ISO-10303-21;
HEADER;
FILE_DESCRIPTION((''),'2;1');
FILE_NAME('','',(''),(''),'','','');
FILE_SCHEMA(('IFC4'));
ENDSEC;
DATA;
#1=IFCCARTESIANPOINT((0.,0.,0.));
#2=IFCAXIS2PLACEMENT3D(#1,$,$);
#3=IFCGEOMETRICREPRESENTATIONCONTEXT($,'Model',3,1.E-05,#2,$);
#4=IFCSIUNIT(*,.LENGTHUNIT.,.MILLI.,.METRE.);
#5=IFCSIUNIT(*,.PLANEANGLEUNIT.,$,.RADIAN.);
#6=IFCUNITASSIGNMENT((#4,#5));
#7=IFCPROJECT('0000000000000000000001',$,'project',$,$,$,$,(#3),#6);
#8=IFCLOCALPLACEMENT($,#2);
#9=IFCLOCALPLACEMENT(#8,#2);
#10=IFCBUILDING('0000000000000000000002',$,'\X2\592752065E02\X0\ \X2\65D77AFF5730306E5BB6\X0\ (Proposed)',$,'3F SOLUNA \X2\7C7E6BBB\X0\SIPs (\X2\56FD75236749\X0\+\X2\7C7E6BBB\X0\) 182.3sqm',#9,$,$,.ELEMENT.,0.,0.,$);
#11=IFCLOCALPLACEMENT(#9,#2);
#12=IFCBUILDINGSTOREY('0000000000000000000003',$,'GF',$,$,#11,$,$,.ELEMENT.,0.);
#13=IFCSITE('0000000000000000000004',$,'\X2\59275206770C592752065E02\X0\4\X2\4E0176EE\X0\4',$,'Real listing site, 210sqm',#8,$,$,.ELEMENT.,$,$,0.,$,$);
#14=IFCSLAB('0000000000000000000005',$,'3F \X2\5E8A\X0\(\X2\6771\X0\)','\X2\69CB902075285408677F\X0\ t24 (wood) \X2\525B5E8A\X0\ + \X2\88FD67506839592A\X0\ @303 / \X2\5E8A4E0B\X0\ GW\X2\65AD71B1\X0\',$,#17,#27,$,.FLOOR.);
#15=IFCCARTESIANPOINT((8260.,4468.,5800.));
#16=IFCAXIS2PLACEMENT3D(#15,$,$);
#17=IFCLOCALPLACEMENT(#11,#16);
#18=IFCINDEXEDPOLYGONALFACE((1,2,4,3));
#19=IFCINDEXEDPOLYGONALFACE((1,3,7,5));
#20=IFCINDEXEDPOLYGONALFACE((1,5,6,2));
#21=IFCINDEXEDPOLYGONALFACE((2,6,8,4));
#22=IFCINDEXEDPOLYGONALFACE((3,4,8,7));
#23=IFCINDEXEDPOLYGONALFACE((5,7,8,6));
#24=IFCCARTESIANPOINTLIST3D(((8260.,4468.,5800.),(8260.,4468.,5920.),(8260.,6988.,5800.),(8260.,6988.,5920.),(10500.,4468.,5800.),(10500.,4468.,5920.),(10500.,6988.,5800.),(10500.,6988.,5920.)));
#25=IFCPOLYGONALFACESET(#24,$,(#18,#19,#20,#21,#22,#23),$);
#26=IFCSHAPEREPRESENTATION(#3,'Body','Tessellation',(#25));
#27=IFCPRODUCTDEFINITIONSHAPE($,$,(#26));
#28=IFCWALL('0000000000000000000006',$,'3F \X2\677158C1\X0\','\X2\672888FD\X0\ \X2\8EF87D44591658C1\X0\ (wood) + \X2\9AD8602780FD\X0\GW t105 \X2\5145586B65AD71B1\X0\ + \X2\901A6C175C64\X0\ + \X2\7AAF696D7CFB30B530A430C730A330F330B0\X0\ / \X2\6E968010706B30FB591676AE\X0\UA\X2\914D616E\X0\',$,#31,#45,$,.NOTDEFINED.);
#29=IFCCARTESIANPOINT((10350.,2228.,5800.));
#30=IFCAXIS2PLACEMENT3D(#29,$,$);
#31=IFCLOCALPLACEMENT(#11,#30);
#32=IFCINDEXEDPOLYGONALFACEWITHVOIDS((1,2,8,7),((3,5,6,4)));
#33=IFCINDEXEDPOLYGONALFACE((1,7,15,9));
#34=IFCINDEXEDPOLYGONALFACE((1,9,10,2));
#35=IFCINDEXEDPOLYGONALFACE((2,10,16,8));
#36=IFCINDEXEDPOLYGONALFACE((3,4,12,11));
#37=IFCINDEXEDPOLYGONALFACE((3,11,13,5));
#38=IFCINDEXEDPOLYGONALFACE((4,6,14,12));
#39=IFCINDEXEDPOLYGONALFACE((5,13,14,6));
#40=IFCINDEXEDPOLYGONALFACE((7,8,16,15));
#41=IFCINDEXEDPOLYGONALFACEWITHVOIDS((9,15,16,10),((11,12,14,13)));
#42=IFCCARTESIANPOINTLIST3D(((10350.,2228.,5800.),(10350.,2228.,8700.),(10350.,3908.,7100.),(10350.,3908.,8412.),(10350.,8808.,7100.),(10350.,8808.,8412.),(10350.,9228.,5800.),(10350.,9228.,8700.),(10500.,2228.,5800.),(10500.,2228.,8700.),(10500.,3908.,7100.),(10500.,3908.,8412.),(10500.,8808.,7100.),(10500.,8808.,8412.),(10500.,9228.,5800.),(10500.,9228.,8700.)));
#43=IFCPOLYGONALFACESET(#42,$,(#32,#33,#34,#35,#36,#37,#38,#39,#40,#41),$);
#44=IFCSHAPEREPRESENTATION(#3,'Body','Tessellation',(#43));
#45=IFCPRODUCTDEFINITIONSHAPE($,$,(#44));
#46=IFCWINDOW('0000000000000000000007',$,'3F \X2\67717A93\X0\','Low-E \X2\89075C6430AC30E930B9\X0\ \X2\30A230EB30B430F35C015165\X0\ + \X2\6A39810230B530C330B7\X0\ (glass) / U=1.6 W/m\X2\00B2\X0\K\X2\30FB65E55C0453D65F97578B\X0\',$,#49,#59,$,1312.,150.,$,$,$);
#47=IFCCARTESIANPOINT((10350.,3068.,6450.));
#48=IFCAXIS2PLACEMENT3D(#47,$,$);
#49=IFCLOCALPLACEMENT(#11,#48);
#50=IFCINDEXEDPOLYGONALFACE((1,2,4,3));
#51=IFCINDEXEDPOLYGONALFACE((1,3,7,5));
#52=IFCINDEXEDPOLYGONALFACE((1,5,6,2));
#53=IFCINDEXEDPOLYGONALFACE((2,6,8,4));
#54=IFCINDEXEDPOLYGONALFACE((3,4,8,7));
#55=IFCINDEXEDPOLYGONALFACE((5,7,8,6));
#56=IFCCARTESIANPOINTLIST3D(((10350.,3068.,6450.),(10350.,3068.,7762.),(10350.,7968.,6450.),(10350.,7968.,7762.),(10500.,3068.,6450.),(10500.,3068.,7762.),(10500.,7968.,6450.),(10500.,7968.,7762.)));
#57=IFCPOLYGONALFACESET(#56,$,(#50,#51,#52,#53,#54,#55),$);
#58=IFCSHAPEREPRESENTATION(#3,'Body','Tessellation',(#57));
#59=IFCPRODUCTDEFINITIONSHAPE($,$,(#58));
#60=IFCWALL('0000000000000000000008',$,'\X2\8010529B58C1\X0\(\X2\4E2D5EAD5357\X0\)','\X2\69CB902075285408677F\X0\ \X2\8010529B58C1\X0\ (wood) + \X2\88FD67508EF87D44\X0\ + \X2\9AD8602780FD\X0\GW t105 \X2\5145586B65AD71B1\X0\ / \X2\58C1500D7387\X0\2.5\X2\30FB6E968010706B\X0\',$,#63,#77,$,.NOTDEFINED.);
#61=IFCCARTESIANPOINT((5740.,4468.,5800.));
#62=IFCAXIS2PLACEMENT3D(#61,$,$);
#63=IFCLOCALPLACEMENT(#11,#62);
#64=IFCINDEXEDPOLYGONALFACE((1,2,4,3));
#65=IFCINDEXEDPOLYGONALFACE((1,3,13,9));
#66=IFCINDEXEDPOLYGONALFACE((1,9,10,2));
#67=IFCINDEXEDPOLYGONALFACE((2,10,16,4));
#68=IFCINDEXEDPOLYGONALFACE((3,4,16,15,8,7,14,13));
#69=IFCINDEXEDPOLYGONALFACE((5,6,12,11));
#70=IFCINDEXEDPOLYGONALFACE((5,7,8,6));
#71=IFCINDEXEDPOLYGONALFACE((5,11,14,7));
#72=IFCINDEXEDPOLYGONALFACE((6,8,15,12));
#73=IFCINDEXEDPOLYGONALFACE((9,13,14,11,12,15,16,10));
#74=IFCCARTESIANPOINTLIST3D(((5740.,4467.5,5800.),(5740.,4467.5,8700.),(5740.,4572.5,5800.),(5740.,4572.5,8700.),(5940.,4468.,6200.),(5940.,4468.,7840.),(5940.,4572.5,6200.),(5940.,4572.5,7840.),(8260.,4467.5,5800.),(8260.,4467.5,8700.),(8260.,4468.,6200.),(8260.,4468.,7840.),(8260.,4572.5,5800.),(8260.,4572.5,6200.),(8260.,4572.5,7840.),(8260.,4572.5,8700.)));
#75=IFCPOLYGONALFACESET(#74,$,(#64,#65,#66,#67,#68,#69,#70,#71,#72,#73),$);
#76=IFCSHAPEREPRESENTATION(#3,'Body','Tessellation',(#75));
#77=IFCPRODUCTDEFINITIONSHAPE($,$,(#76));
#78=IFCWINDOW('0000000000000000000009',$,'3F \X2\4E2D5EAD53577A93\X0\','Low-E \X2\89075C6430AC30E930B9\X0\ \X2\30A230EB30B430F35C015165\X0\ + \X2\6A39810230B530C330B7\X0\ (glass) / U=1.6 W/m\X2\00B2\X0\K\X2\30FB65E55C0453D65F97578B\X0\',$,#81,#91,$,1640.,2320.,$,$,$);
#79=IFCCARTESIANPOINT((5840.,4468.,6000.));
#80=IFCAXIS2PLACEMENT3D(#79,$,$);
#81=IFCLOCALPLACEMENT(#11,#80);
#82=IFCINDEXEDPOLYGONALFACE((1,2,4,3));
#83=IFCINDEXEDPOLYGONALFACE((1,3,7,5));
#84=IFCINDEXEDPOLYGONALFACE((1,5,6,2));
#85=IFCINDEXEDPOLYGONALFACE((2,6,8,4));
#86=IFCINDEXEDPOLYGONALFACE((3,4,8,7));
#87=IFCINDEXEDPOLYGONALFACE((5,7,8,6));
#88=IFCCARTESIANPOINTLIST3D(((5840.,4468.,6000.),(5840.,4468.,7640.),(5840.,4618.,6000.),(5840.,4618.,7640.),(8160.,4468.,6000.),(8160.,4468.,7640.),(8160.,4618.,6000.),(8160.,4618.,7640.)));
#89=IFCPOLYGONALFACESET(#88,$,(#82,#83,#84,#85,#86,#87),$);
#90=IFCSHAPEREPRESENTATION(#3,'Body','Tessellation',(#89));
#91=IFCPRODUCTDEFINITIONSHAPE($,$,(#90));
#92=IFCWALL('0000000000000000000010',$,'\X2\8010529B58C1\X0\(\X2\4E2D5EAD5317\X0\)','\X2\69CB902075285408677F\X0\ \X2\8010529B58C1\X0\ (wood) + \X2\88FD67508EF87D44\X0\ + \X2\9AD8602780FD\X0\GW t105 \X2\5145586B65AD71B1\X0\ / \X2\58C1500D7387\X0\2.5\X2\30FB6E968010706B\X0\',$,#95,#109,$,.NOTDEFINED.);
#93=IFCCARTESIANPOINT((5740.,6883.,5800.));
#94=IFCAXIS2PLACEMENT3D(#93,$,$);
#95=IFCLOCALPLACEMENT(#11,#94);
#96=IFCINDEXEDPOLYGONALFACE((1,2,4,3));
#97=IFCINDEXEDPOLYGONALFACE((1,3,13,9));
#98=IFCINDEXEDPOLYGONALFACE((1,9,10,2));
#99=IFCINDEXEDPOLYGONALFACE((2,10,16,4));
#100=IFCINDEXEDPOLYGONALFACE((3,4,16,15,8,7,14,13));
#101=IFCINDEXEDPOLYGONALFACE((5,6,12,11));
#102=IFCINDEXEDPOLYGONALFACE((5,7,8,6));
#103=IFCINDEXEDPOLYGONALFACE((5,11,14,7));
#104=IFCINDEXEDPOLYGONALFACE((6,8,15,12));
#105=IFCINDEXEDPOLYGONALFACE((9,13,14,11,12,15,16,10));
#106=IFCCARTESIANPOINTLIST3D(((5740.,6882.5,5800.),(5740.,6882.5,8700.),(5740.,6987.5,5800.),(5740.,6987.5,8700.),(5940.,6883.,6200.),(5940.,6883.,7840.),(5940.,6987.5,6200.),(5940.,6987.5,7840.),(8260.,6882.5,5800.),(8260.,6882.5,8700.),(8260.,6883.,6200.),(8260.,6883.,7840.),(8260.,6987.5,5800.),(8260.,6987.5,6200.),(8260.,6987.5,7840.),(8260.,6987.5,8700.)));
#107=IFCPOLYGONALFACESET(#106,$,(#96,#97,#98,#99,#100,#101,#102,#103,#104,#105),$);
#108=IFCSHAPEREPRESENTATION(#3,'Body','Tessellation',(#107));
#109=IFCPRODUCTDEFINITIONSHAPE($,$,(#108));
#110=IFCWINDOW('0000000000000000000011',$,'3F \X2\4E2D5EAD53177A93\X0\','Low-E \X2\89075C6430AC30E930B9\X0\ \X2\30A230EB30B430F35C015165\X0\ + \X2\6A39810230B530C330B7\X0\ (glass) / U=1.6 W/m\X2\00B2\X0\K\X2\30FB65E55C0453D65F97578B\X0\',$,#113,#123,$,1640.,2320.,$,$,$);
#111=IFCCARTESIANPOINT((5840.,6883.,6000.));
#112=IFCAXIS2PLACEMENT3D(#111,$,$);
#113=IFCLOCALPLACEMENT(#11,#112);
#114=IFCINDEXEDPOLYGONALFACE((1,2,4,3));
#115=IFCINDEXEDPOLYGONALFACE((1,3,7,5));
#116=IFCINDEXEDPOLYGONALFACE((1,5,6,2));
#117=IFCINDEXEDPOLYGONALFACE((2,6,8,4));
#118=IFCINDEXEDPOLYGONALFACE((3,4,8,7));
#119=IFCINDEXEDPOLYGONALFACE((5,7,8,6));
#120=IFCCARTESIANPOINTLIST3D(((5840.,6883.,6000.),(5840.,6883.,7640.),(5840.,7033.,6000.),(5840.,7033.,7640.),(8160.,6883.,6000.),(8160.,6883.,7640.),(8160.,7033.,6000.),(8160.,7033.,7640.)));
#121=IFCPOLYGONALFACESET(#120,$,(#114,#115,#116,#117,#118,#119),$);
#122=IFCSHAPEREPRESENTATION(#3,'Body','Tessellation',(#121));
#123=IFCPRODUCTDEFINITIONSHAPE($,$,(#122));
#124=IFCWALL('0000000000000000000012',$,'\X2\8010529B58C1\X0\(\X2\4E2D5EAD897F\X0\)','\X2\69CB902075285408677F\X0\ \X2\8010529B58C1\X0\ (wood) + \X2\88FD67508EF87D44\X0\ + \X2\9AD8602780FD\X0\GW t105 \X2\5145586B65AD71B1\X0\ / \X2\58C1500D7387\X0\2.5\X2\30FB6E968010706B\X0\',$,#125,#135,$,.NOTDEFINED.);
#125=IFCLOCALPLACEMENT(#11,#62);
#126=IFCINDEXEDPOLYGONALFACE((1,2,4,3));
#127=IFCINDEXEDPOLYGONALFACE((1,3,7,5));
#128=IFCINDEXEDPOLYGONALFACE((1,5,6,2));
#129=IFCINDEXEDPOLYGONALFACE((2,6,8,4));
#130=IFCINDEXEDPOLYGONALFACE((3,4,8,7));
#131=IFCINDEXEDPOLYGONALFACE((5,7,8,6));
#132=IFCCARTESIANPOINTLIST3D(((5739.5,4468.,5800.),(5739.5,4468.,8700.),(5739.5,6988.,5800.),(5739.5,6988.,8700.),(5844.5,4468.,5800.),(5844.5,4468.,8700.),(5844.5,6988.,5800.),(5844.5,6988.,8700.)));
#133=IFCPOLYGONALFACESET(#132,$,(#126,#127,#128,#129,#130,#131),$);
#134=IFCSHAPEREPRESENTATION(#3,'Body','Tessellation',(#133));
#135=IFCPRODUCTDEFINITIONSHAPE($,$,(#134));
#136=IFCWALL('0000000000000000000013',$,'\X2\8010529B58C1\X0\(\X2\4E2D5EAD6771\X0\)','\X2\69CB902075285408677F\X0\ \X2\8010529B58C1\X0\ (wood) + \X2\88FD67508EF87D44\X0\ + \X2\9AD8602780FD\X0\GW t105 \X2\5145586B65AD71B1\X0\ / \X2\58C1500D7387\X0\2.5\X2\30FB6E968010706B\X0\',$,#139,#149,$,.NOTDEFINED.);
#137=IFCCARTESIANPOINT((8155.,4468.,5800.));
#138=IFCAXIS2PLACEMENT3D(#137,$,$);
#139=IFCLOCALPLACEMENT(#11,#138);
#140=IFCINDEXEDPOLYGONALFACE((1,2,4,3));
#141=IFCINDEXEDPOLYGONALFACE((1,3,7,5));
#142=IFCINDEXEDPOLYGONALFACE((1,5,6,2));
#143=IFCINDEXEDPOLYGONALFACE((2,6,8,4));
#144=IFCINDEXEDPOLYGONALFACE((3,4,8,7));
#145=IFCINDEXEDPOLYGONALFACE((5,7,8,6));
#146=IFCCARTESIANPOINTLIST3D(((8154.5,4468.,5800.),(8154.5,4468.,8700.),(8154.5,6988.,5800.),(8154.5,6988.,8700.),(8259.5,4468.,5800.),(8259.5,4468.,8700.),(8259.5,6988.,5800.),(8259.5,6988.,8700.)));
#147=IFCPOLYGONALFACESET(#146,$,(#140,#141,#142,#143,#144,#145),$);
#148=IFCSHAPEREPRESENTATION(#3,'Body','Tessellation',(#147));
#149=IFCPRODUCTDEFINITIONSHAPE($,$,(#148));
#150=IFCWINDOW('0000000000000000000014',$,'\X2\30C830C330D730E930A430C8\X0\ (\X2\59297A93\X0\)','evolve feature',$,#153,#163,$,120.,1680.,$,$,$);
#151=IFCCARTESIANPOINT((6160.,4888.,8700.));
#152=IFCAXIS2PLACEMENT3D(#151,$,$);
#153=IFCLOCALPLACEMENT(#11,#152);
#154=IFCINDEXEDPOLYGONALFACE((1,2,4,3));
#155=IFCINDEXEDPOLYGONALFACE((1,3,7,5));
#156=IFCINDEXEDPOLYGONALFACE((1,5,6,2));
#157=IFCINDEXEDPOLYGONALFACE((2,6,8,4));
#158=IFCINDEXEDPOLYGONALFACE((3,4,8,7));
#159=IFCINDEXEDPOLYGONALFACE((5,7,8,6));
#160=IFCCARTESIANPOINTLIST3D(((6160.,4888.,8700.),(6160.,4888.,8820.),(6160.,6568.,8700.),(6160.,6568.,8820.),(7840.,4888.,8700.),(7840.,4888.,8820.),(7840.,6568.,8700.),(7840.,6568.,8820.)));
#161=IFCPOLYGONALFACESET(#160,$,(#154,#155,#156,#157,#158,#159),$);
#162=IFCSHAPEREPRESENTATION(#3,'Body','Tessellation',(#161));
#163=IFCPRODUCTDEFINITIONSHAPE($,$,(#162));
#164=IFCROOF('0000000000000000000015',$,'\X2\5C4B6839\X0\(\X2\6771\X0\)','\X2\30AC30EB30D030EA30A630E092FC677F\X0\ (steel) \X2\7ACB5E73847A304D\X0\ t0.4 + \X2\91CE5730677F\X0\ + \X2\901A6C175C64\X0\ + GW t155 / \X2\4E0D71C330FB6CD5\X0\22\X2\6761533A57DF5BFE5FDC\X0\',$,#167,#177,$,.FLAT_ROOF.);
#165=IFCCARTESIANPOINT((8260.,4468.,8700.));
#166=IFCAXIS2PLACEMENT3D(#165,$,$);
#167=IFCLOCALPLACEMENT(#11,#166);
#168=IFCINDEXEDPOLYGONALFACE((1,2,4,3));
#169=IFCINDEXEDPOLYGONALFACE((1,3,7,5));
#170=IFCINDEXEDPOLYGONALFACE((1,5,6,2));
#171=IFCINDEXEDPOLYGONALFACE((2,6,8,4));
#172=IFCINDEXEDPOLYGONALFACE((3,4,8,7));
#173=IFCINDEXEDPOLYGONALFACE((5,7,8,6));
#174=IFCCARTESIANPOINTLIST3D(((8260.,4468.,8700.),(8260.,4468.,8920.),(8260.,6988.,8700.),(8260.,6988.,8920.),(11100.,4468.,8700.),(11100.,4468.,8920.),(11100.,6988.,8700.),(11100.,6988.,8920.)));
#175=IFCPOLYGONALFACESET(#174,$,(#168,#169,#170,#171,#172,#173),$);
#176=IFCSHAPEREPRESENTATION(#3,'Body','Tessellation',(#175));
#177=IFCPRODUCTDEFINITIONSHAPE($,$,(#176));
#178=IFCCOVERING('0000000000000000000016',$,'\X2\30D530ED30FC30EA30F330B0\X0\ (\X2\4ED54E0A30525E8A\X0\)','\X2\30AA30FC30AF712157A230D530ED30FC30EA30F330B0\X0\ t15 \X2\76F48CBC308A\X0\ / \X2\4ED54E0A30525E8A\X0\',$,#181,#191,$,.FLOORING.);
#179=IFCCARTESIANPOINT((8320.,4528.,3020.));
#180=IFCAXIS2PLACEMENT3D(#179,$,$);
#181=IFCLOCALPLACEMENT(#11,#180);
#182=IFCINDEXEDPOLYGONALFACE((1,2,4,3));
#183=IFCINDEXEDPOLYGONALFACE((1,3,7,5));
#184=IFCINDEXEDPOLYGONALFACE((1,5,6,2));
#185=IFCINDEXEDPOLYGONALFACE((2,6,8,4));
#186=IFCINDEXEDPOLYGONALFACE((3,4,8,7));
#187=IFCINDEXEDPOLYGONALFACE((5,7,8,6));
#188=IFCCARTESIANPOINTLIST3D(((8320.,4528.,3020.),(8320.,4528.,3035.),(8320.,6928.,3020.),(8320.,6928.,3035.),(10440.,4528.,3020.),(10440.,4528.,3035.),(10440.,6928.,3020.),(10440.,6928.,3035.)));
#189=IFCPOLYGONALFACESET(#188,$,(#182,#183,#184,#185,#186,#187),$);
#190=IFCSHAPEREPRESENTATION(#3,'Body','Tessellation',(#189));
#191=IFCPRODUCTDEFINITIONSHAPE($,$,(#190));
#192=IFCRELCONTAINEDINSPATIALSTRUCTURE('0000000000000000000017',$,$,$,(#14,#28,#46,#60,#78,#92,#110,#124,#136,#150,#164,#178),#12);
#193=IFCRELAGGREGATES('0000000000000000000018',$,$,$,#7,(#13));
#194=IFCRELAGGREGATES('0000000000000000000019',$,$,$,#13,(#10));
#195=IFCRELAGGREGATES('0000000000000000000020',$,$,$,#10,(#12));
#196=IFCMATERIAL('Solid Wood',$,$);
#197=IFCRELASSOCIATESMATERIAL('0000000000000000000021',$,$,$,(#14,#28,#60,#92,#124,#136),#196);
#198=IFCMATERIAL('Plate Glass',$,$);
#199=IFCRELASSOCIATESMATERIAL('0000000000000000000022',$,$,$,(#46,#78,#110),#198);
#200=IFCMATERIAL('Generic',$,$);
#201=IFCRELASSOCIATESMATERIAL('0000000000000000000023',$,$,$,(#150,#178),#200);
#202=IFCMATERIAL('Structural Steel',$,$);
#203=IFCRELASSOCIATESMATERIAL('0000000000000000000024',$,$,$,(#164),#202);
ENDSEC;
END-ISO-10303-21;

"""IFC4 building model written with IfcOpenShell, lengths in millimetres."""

from ifc_helpers import new_model, si_unit, frame, frame_2d, origin, place, context, project, spatial, rectangle, extrude, material, element, fill, save


model = new_model("IFC4")

# Units and contexts
model_context = context("Model", 3, precision=1e-05, world=origin())
ifc_project = project(units=[si_unit("LENGTHUNIT", "METRE", prefix="MILLI"), si_unit("PLANEANGLEUNIT", "RADIAN")], contexts=[model_context])

# Site, building, storey
site_placement = place(None, origin())
site = spatial("IfcSite", under=ifc_project, at=site_placement, Name="大分県大分市4丁目4", ObjectType="Real listing site, 210sqm", CompositionType="ELEMENT", RefElevation=0.0)
building_placement = place(site_placement, origin())
building = spatial("IfcBuilding", under=site, at=building_placement, Name="大分市 旗竿地の家 (Proposed)", ObjectType="3F SOLUNA 籾殻SIPs (国産杉+籾殻) 182.3sqm", CompositionType="ELEMENT", ElevationOfRefHeight=0.0, ElevationOfTerrain=0.0)
storey_placement = place(building_placement, origin())
storey = spatial("IfcBuildingStorey", under=building, at=storey_placement, Name="GF", CompositionType="ELEMENT", Elevation=0.0)

# Slab
ifc_material_1 = material(Name="Solid Wood")
slab_placement = place(storey_placement, frame((8260.0, 4468.0, 5800.0)))
element("IfcSlab", 1, at=slab_placement, inside=storey, material=ifc_material_1, Name="3F 床(東)", Description="構造用合板 t24 (wood) 剛床 + 製材根太 @303 / 床下 GW断熱", PredefinedType="FLOOR", context=model_context, shape_type="SweptSolid", body=[
    extrude(rectangle(XDim=2240.0, YDim=2520.0, at=frame_2d((1120.0, 1260.0))), frame((8260.0, 4468.0, 5800.0)), (0.0, 0.0, 1.0), 120.0),
])

# Walls, openings, windows
wall_1_placement = place(storey_placement, frame((10350.0, 2228.0, 5800.0)))
wall_1 = element("IfcWall", 2, at=wall_1_placement, inside=storey, material=ifc_material_1, Name="3F 東壁", Description="木製 軸組外壁 (wood) + 高性能GW t105 充填断熱 + 通気層 + 窯業系サイディング / 準耐火・外皮UA配慮", PredefinedType="NOTDEFINED", context=model_context, shape_type="SweptSolid", body=[
    extrude(rectangle(XDim=150.0, YDim=7000.0, at=frame_2d((75.0, 3500.0))), frame((10350.0, 2228.0, 5800.0)), (0.0, 0.0, 1.0), 2900.0),
])
opening_1_placement = place(storey_placement, frame((10350.0, 3068.0, 6450.0)))
opening_1 = element("IfcOpeningElement", 3, at=opening_1_placement, cuts=wall_1, PredefinedType="NOTDEFINED", context=model_context, shape_type="SweptSolid", body=[
    extrude(rectangle(XDim=150.0, YDim=4900.0, at=frame_2d((75.0, 2450.0))), frame((10350.0, 3068.0, 6450.0)), (0.0, 0.0, 1.0), 1312.0),
])
ifc_material_2 = material(Name="Plate Glass")
window_1_placement = place(storey_placement, frame((10350.0, 3068.0, 6450.0)))
window_1 = element("IfcWindow", 4, at=window_1_placement, inside=storey, material=ifc_material_2, Name="3F 東窓", Description="Low-E 複層ガラス アルゴン封入 + 樹脂サッシ (glass) / U=1.6 W/m²K・日射取得型", OverallHeight=1312.0, OverallWidth=150.0, context=model_context, shape_type="SweptSolid", body=[
    extrude(rectangle(XDim=150.0, YDim=4900.0, at=frame_2d((75.0, 2450.0))), frame((10350.0, 3068.0, 6450.0)), (0.0, 0.0, 1.0), 1312.0),
])
fill(opening_1, window_1)
wall_2_placement = place(storey_placement, frame((5740.0, 4468.0, 5800.0)))
wall_2 = element("IfcWall", 5, at=wall_2_placement, inside=storey, material=ifc_material_1, Name="耐力壁(中庭南)", Description="構造用合板 耐力壁 (wood) + 製材軸組 + 高性能GW t105 充填断熱 / 壁倍率2.5・準耐火", PredefinedType="NOTDEFINED", context=model_context, shape_type="SweptSolid", body=[
    extrude(rectangle(XDim=2520.0, YDim=105.0, at=frame_2d((1260.0, 52.0))), frame((5740.0, 4468.0, 5800.0)), (0.0, 0.0, 1.0), 2900.0),
])
opening_2_placement = place(storey_placement, frame((5840.0, 4468.0, 6000.0)))
opening_2 = element("IfcOpeningElement", 6, at=opening_2_placement, cuts=wall_2, PredefinedType="NOTDEFINED", context=model_context, shape_type="SweptSolid", body=[
    extrude(rectangle(XDim=2320.0, YDim=150.0, at=frame_2d((1160.0, 75.0))), frame((5840.0, 4468.0, 6000.0)), (0.0, 0.0, 1.0), 1640.0),
])
window_2_placement = place(storey_placement, frame((5840.0, 4468.0, 6000.0)))
window_2 = element("IfcWindow", 7, at=window_2_placement, inside=storey, material=ifc_material_2, Name="3F 中庭南窓", Description="Low-E 複層ガラス アルゴン封入 + 樹脂サッシ (glass) / U=1.6 W/m²K・日射取得型", OverallHeight=1640.0, OverallWidth=2320.0, context=model_context, shape_type="SweptSolid", body=[
    extrude(rectangle(XDim=2320.0, YDim=150.0, at=frame_2d((1160.0, 75.0))), frame((5840.0, 4468.0, 6000.0)), (0.0, 0.0, 1.0), 1640.0),
])
fill(opening_2, window_2)
wall_3_placement = place(storey_placement, frame((5740.0, 6883.0, 5800.0)))
wall_3 = element("IfcWall", 8, at=wall_3_placement, inside=storey, material=ifc_material_1, Name="耐力壁(中庭北)", Description="構造用合板 耐力壁 (wood) + 製材軸組 + 高性能GW t105 充填断熱 / 壁倍率2.5・準耐火", PredefinedType="NOTDEFINED", context=model_context, shape_type="SweptSolid", body=[
    extrude(rectangle(XDim=2520.0, YDim=105.0, at=frame_2d((1260.0, 52.0))), frame((5740.0, 6883.0, 5800.0)), (0.0, 0.0, 1.0), 2900.0),
])
opening_3_placement = place(storey_placement, frame((5840.0, 6883.0, 6000.0)))
opening_3 = element("IfcOpeningElement", 9, at=opening_3_placement, cuts=wall_3, PredefinedType="NOTDEFINED", context=model_context, shape_type="SweptSolid", body=[
    extrude(rectangle(XDim=2320.0, YDim=150.0, at=frame_2d((1160.0, 75.0))), frame((5840.0, 6883.0, 6000.0)), (0.0, 0.0, 1.0), 1640.0),
])
window_3_placement = place(storey_placement, frame((5840.0, 6883.0, 6000.0)))
window_3 = element("IfcWindow", 10, at=window_3_placement, inside=storey, material=ifc_material_2, Name="3F 中庭北窓", Description="Low-E 複層ガラス アルゴン封入 + 樹脂サッシ (glass) / U=1.6 W/m²K・日射取得型", OverallHeight=1640.0, OverallWidth=2320.0, context=model_context, shape_type="SweptSolid", body=[
    extrude(rectangle(XDim=2320.0, YDim=150.0, at=frame_2d((1160.0, 75.0))), frame((5840.0, 6883.0, 6000.0)), (0.0, 0.0, 1.0), 1640.0),
])
fill(opening_3, window_3)

# Walls
wall_4_placement = place(storey_placement, frame((5740.0, 4468.0, 5800.0)))
element("IfcWall", 11, at=wall_4_placement, inside=storey, material=ifc_material_1, Name="耐力壁(中庭西)", Description="構造用合板 耐力壁 (wood) + 製材軸組 + 高性能GW t105 充填断熱 / 壁倍率2.5・準耐火", PredefinedType="NOTDEFINED", context=model_context, shape_type="SweptSolid", body=[
    extrude(rectangle(XDim=105.0, YDim=2520.0, at=frame_2d((52.0, 1260.0))), frame((5740.0, 4468.0, 5800.0)), (0.0, 0.0, 1.0), 2900.0),
])
wall_5_placement = place(storey_placement, frame((8155.0, 4468.0, 5800.0)))
element("IfcWall", 12, at=wall_5_placement, inside=storey, material=ifc_material_1, Name="耐力壁(中庭東)", Description="構造用合板 耐力壁 (wood) + 製材軸組 + 高性能GW t105 充填断熱 / 壁倍率2.5・準耐火", PredefinedType="NOTDEFINED", context=model_context, shape_type="SweptSolid", body=[
    extrude(rectangle(XDim=105.0, YDim=2520.0, at=frame_2d((52.0, 1260.0))), frame((8155.0, 4468.0, 5800.0)), (0.0, 0.0, 1.0), 2900.0),
])

# Window
ifc_material_3 = material(Name="Generic")
window_4_placement = place(storey_placement, frame((6160.0, 4888.0, 8700.0)))
element("IfcWindow", 13, at=window_4_placement, inside=storey, material=ifc_material_3, Name="トップライト (天窓)", Description="evolve feature", OverallHeight=120.0, OverallWidth=1680.0, context=model_context, shape_type="SweptSolid", body=[
    extrude(rectangle(XDim=1680.0, YDim=1680.0, at=frame_2d((840.0, 840.0))), frame((6160.0, 4888.0, 8700.0)), (0.0, 0.0, 1.0), 120.0),
])

# Roof
ifc_material_4 = material(Name="Structural Steel")
for number, where, name in (
    (14, (8260.0, 4468.0, 8700.0), "屋根(東)"),
):
    element("IfcRoof", number, at=place(storey_placement, frame(where)), inside=storey, material=ifc_material_4, Name=name, Description="ガルバリウム鋼板 (steel) 立平葺き t0.4 + 野地板 + 通気層 + GW t155 / 不燃・法22条区域対応", PredefinedType="FLAT_ROOF", context=model_context, shape_type="SweptSolid", body=[
        extrude(rectangle(XDim=2840.0, YDim=2520.0, at=frame_2d((1420.0, 1260.0))), frame((8260.0, 4468.0, 8700.0)), (0.0, 0.0, 1.0), 220.0),
    ])

# Covering
covering_1_placement = place(storey_placement, frame((8320.0, 4528.0, 3020.0)))
element("IfcCovering", 15, at=covering_1_placement, inside=storey, material=ifc_material_3, Name="フローリング (仕上げ床)", Description="オーク無垢フローリング t15 直貼り / 仕上げ床", PredefinedType="FLOORING", context=model_context, shape_type="SweptSolid", body=[
    extrude(rectangle(XDim=2120.0, YDim=2400.0, at=frame_2d((1060.0, 1200.0))), frame((8320.0, 4528.0, 3020.0)), (0.0, 0.0, 1.0), 15.0),
])

save(model, "model.ifc")
